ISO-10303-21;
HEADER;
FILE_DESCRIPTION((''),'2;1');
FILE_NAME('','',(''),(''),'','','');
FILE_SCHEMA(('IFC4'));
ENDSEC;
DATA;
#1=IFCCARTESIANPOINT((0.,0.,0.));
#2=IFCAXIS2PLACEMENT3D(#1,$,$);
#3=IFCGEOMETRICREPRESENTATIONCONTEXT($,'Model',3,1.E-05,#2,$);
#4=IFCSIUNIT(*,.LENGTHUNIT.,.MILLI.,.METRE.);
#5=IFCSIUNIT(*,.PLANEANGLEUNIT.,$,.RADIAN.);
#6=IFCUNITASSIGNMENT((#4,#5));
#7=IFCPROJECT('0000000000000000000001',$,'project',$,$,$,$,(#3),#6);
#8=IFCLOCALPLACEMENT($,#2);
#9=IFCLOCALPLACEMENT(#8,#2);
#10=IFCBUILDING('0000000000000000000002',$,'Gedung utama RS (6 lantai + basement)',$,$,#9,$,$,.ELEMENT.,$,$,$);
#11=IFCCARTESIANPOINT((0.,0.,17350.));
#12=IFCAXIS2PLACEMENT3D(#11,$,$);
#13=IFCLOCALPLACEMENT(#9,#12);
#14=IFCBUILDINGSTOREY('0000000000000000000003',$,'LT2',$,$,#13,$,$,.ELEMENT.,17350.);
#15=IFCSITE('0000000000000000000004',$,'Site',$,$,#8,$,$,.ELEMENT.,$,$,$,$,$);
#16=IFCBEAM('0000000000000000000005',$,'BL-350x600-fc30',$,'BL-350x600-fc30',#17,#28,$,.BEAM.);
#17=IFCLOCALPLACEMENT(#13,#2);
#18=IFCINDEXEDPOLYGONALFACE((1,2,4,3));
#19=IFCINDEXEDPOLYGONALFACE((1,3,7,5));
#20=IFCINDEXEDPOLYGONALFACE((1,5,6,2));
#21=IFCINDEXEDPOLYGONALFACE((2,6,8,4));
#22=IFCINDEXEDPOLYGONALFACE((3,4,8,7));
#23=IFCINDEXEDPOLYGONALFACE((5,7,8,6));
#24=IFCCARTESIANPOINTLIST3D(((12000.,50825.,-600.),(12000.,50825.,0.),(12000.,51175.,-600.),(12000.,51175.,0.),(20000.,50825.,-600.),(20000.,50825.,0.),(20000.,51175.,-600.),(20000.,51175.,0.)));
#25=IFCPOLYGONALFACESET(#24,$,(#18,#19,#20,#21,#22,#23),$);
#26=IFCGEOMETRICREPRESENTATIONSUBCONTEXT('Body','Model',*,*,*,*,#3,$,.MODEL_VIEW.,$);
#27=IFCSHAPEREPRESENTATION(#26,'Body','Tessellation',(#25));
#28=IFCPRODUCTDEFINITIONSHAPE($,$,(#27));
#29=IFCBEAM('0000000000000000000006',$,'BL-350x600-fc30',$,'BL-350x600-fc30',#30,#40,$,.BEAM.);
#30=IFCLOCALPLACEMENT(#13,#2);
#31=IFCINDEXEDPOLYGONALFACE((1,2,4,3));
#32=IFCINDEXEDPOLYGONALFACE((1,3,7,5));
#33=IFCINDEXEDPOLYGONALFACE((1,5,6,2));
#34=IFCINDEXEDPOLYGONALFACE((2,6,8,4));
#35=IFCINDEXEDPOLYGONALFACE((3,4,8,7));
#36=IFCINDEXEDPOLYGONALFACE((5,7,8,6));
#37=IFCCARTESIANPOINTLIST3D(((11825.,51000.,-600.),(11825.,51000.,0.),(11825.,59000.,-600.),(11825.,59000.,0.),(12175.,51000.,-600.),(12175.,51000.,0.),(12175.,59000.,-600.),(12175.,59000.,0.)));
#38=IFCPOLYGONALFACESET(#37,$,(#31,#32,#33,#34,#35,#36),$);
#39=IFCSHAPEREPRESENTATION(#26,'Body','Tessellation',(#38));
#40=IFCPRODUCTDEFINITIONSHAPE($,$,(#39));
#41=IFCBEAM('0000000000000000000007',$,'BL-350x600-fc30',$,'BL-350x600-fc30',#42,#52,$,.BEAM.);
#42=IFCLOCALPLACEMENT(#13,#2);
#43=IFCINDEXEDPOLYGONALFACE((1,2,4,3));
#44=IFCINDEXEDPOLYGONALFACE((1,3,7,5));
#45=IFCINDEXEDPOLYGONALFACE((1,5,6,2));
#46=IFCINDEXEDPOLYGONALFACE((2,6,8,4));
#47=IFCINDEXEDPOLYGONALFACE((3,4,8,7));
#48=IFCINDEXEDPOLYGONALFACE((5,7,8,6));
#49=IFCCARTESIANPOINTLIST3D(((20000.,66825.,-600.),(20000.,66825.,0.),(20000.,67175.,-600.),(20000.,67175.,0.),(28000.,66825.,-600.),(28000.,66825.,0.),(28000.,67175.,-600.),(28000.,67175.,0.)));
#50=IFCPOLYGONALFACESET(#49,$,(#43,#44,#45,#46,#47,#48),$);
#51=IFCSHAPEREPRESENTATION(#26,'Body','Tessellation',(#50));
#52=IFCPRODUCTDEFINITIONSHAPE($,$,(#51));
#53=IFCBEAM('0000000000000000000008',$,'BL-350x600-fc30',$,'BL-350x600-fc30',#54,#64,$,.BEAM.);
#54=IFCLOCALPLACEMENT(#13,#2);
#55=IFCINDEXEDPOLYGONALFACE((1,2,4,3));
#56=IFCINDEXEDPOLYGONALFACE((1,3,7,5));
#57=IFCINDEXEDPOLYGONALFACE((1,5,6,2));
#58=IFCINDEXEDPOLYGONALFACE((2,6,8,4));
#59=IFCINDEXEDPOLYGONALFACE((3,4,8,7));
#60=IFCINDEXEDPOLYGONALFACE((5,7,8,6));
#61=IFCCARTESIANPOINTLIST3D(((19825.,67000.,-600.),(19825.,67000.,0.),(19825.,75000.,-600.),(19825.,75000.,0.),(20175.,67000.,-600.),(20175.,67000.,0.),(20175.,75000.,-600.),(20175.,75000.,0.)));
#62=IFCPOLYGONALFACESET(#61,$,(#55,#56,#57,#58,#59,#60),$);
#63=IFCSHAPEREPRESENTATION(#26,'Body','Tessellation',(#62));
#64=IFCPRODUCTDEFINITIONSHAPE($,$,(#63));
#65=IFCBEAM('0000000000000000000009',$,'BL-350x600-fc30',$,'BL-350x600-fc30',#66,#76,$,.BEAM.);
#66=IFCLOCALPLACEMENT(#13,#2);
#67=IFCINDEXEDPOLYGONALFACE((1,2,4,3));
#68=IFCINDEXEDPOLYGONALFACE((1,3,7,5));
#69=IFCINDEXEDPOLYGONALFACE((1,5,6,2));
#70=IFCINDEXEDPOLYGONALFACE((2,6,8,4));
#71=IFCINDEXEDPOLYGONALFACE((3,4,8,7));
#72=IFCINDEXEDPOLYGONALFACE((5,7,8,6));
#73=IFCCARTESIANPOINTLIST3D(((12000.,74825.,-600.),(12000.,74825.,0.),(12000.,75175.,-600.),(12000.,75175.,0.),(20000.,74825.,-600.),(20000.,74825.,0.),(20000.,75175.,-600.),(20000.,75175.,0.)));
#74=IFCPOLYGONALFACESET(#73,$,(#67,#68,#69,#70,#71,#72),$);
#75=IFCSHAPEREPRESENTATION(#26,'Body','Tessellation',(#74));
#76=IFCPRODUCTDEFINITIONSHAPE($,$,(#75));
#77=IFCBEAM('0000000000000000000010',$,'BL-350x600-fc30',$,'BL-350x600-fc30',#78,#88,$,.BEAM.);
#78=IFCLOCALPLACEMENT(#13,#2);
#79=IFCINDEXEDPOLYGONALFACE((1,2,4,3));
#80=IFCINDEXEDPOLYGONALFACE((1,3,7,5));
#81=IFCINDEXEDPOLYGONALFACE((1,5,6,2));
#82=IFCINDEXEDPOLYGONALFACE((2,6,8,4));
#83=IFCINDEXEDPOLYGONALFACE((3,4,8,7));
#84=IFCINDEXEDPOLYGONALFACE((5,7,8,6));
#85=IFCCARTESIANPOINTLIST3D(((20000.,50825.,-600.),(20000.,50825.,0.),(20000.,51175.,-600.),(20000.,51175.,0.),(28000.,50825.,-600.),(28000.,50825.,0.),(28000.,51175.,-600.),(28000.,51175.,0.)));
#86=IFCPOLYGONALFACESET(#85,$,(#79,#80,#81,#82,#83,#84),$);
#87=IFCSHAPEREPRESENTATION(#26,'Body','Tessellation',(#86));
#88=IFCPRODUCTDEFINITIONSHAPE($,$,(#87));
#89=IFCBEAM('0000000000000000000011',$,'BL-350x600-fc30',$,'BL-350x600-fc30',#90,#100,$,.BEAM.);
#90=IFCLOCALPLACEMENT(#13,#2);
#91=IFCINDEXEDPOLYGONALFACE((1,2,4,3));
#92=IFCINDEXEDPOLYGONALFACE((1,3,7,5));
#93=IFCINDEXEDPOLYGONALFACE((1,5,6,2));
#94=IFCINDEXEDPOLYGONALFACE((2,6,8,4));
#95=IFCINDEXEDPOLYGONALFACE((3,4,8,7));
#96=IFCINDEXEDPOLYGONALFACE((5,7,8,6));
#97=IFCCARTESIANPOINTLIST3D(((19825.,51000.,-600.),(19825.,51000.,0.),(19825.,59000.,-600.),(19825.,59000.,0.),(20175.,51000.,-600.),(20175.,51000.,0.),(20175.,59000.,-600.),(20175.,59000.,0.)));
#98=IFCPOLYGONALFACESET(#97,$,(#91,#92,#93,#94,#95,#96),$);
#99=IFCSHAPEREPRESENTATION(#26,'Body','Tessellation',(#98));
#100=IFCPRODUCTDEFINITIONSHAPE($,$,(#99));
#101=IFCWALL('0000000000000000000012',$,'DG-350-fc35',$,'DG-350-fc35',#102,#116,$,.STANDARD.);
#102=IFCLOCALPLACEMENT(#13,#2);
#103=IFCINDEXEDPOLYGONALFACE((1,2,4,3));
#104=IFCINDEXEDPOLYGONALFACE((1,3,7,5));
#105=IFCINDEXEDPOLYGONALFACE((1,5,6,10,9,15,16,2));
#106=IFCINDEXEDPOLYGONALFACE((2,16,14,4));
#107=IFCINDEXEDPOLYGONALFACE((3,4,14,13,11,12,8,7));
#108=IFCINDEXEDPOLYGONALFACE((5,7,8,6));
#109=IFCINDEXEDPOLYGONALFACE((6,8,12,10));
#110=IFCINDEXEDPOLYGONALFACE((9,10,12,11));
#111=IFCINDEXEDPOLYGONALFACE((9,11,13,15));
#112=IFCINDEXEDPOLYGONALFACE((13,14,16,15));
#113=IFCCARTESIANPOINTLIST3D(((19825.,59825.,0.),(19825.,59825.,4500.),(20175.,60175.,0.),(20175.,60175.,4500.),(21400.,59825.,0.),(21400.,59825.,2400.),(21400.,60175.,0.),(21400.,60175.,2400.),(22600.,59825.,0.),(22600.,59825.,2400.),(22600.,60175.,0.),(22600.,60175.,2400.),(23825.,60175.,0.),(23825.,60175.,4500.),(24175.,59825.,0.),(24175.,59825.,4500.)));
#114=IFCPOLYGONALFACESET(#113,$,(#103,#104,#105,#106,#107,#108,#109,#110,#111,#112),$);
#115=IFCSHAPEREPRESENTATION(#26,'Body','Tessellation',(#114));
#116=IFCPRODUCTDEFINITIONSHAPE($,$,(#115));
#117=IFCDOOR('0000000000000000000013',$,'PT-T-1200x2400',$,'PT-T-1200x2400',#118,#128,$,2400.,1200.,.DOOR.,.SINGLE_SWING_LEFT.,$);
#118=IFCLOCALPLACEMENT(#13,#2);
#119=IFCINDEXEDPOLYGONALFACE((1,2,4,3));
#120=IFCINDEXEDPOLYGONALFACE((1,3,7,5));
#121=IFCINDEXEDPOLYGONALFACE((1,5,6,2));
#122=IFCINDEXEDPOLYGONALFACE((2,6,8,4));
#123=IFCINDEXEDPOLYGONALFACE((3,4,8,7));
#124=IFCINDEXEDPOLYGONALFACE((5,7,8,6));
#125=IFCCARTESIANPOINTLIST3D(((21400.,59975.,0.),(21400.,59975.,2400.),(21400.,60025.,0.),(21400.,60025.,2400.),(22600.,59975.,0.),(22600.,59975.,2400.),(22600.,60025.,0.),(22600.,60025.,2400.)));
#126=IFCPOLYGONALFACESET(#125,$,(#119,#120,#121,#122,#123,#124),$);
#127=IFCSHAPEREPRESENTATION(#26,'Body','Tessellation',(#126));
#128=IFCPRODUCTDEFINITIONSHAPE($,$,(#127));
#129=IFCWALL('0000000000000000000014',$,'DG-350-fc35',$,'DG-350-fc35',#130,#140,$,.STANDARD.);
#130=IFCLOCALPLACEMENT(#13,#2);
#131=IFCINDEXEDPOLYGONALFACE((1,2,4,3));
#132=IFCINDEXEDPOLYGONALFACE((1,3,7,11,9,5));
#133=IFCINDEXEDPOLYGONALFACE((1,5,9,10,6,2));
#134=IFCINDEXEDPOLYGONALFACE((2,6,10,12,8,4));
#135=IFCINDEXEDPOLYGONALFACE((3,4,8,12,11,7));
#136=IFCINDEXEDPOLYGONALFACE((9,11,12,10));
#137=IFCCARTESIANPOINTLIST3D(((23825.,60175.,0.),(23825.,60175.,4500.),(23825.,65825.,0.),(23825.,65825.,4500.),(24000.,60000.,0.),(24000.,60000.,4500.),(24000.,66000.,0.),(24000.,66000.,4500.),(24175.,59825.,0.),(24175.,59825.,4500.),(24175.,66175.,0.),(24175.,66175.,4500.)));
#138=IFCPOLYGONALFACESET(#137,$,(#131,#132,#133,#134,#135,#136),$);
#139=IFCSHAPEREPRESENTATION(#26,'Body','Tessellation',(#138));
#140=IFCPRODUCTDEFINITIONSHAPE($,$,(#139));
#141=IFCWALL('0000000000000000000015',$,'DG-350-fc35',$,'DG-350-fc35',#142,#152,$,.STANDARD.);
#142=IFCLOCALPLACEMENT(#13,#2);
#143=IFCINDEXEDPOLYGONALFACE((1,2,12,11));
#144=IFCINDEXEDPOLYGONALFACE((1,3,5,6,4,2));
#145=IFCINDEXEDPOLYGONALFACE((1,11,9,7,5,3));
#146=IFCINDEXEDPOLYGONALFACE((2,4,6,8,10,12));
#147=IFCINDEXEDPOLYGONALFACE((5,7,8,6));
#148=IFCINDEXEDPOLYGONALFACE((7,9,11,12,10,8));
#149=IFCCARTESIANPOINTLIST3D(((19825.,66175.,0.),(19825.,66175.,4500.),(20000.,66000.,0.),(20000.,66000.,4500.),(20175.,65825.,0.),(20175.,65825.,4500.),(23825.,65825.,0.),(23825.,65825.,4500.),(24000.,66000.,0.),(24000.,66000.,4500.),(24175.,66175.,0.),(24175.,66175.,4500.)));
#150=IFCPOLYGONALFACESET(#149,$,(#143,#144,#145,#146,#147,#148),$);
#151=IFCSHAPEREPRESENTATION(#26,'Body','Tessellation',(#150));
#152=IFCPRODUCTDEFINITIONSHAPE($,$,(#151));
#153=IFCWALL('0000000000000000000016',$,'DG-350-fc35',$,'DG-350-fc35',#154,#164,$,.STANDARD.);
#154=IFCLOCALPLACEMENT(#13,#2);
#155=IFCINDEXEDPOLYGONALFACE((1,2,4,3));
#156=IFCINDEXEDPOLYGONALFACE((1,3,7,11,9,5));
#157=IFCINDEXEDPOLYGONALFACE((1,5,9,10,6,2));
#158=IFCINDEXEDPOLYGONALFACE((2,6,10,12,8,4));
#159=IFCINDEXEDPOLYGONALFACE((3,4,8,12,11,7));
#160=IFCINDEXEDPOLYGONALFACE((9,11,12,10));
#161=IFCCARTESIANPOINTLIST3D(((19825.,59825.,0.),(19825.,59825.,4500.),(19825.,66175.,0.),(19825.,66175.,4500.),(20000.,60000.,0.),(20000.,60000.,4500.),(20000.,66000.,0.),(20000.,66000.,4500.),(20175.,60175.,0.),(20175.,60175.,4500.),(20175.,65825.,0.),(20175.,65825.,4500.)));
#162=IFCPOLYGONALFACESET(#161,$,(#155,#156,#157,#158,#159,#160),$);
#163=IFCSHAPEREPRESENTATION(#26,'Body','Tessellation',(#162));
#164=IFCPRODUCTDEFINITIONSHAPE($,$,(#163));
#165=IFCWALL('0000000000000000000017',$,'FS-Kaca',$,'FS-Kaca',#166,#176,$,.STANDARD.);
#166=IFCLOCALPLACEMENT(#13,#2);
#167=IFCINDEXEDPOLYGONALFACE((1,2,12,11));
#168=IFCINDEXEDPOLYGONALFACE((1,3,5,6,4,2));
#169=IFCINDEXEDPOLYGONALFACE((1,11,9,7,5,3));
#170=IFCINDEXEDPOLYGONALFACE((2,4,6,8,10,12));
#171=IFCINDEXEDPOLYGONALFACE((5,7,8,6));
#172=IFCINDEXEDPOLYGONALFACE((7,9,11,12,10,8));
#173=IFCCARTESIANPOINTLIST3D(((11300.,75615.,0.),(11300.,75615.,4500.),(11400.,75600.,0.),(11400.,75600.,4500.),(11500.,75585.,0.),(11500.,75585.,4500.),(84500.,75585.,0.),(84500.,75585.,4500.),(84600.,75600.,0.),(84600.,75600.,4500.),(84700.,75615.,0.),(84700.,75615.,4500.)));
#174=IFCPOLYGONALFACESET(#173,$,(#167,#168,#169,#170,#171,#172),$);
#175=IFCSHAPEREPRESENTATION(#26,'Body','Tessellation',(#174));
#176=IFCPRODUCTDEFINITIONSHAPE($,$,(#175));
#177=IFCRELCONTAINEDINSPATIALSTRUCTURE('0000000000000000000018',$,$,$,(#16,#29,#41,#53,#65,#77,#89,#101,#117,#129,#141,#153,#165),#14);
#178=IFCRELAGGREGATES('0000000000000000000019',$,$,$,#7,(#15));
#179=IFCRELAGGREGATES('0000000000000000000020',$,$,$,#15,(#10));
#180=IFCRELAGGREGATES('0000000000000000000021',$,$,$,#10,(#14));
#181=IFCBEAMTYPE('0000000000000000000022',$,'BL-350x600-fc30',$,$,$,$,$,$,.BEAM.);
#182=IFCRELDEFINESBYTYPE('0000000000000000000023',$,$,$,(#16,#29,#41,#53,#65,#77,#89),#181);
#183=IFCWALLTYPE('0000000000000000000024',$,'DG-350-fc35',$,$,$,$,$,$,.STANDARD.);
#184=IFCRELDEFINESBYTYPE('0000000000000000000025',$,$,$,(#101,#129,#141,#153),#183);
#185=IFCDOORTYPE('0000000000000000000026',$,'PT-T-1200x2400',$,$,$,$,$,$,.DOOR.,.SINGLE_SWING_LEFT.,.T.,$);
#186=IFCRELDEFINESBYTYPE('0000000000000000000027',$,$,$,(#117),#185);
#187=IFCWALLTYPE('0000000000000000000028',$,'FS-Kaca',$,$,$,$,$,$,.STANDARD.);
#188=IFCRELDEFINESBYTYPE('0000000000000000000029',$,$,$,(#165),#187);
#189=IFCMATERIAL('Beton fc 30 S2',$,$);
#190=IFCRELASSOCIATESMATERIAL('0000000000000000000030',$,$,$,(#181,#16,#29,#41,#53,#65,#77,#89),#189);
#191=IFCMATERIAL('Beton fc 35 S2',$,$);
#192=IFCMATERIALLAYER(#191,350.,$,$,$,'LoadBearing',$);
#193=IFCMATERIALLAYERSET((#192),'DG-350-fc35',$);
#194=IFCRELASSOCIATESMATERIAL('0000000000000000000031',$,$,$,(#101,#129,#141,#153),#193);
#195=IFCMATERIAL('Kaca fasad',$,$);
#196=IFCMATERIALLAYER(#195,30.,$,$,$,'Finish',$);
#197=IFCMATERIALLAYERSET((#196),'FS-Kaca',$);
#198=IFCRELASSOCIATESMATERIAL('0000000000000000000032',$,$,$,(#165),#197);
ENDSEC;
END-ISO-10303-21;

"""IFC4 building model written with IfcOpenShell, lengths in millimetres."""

from ifc_helpers import new_model, si_unit, frame, frame_2d, origin, origin_2d, place, context, subcontext, project, spatial, polyline, rectangle, outline, extrude, material, layer, layer_set, layer_usage, material_profile, profile_set, profile_usage, type_object, element, fill, save


model = new_model("IFC4")

# Units and contexts
model_context = context("Model", 3, precision=1e-05, world=origin())
body_context = subcontext(model_context, "Body", "Model", "MODEL_VIEW")
ifc_project = project(units=[si_unit("LENGTHUNIT", "METRE", prefix="MILLI"), si_unit("PLANEANGLEUNIT", "RADIAN")], contexts=[model_context])

# Site, building, storey
site_placement = place(None, origin())
site = spatial("IfcSite", under=ifc_project, at=site_placement, Name="Site", CompositionType="ELEMENT")
building_placement = place(site_placement, origin())
building = spatial("IfcBuilding", under=site, at=building_placement, Name="Gedung utama RS (6 lantai + basement)", CompositionType="ELEMENT")
storey_placement = place(building_placement, frame((0.0, 0.0, 17350.0)))
storey = spatial("IfcBuildingStorey", under=building, at=storey_placement, Name="LT2", CompositionType="ELEMENT", Elevation=17350.0)

# Beams
ifc_material_1 = material(Name="Beton fc 30 S2")
ifc_material_profile_1 = material_profile(ifc_material_1, rectangle(XDim=350.0, YDim=600.0, at=origin_2d()), Name="BL-350x600-fc30")
ifc_profile_set_1 = profile_set([ifc_material_profile_1], Name="BL-350x600-fc30")
ifc_profile_usage_1 = profile_usage(ifc_profile_set_1, cardinal=8)
beam_type = type_object("IfcBeamType", Name="BL-350x600-fc30", PredefinedType="BEAM", material=ifc_profile_set_1)
beam_1_placement = place(storey_placement, frame((12000.0, 51000.0, -300.0)))
element("IfcBeam", 1, at=beam_1_placement, inside=storey, type_object=beam_type, material=ifc_profile_usage_1, Name="BL-350x600-fc30", ObjectType="BL-350x600-fc30", PredefinedType="BEAM", context=body_context, shape_type="SweptSolid", body=[
    extrude(rectangle(XDim=350.0, YDim=600.0, at=origin_2d()), frame((0.0, 0.0, 0.0), z_axis=(1.0, 0.0, 0.0), x_axis=(0.0, 1.0, 0.0)), (0.0, 0.0, 1.0), 8000.0),
])
beam_2_placement = place(storey_placement, frame((12000.0, 51000.0, -300.0)))
element("IfcBeam", 2, at=beam_2_placement, inside=storey, type_object=beam_type, material=ifc_profile_usage_1, Name="BL-350x600-fc30", ObjectType="BL-350x600-fc30", PredefinedType="BEAM", context=body_context, shape_type="SweptSolid", body=[
    extrude(rectangle(XDim=350.0, YDim=600.0, at=origin_2d()), frame((0.0, 0.0, 0.0), z_axis=(0.0, 1.0, 0.0), x_axis=(-1.0, 0.0, 0.0)), (0.0, 0.0, 1.0), 8000.0),
])
beam_3_placement = place(storey_placement, frame((20000.0, 67000.0, -300.0)))
element("IfcBeam", 3, at=beam_3_placement, inside=storey, type_object=beam_type, material=ifc_profile_usage_1, Name="BL-350x600-fc30", ObjectType="BL-350x600-fc30", PredefinedType="BEAM", context=body_context, shape_type="SweptSolid", body=[
    extrude(rectangle(XDim=350.0, YDim=600.0, at=origin_2d()), frame((0.0, 0.0, 0.0), z_axis=(1.0, 0.0, 0.0), x_axis=(0.0, 1.0, 0.0)), (0.0, 0.0, 1.0), 8000.0),
])
beam_4_placement = place(storey_placement, frame((20000.0, 67000.0, -300.0)))
element("IfcBeam", 4, at=beam_4_placement, inside=storey, type_object=beam_type, material=ifc_profile_usage_1, Name="BL-350x600-fc30", ObjectType="BL-350x600-fc30", PredefinedType="BEAM", context=body_context, shape_type="SweptSolid", body=[
    extrude(rectangle(XDim=350.0, YDim=600.0, at=origin_2d()), frame((0.0, 0.0, 0.0), z_axis=(0.0, 1.0, 0.0), x_axis=(-1.0, 0.0, 0.0)), (0.0, 0.0, 1.0), 8000.0),
])
for number, where, name in (
    (5, (12000.0, 75000.0, -300.0), "BL-350x600-fc30"),
    (6, (20000.0, 51000.0, -300.0), "BL-350x600-fc30"),
):
    element("IfcBeam", number, at=place(storey_placement, frame(where)), inside=storey, type_object=beam_type, material=ifc_profile_usage_1, Name=name, ObjectType="BL-350x600-fc30", PredefinedType="BEAM", context=body_context, shape_type="SweptSolid", body=[
        extrude(rectangle(XDim=350.0, YDim=600.0, at=origin_2d()), frame((0.0, 0.0, 0.0), z_axis=(1.0, 0.0, 0.0), x_axis=(0.0, 1.0, 0.0)), (0.0, 0.0, 1.0), 8000.0),
    ])
beam_5_placement = place(storey_placement, frame((20000.0, 51000.0, -300.0)))
element("IfcBeam", 7, at=beam_5_placement, inside=storey, type_object=beam_type, material=ifc_profile_usage_1, Name="BL-350x600-fc30", ObjectType="BL-350x600-fc30", PredefinedType="BEAM", context=body_context, shape_type="SweptSolid", body=[
    extrude(rectangle(XDim=350.0, YDim=600.0, at=origin_2d()), frame((0.0, 0.0, 0.0), z_axis=(0.0, 1.0, 0.0), x_axis=(-1.0, 0.0, 0.0)), (0.0, 0.0, 1.0), 8000.0),
])

# Wall, opening, door
ifc_material_2 = material(Name="Beton fc 35 S2")
ifc_layer_1 = layer(ifc_material_2, 350.0, Category="LoadBearing")
ifc_layer_set_1 = layer_set([ifc_layer_1], Name="DG-350-fc35")
ifc_layer_usage_1 = layer_usage(ifc_layer_set_1, "AXIS2", "NEGATIVE", 175.0)
wall_type_1 = type_object("IfcWallType", Name="DG-350-fc35", PredefinedType="STANDARD")
wall_1_placement = place(storey_placement, frame((20000.0, 60000.0, 0.0), z_axis=(0.0, 0.0, 1.0), x_axis=(1.0, 0.0, 0.0)))
wall_1 = element("IfcWall", 8, at=wall_1_placement, inside=storey, type_object=wall_type_1, material=ifc_layer_usage_1, Name="DG-350-fc35", ObjectType="DG-350-fc35", PredefinedType="STANDARD", context=body_context, shape_type="SweptSolid", body=[
    extrude(outline(polyline([(-175.0, -175.0), (0.0, 0.0), (175.0, 175.0), (3825.0, 175.0), (4000.0, 0.0), (4175.0, -175.0), (-175.0, -175.0)])), origin(), (0.0, 0.0, 1.0), 4500.0),
])
opening_placement = place(wall_1_placement, frame((1400.0, 0.0, 0.0), z_axis=(0.0, 0.0, 1.0), x_axis=(1.0, 0.0, 0.0)))
opening = element("IfcOpeningElement", 9, at=opening_placement, cuts=wall_1, PredefinedType="OPENING", context=body_context, shape_type="SweptSolid", body=[
    extrude(rectangle(XDim=1200.0, YDim=370.0, at=frame_2d((600.0, 0.0))), origin(), (0.0, 0.0, 1.0), 2400.0),
])
door_type = type_object("IfcDoorType", Name="PT-T-1200x2400", OperationType="SINGLE_SWING_LEFT", ParameterTakesPrecedence=True, PredefinedType="DOOR")
door_placement = place(opening_placement, origin())
door = element("IfcDoor", 10, at=door_placement, inside=storey, type_object=door_type, Name="PT-T-1200x2400", ObjectType="PT-T-1200x2400", OperationType="SINGLE_SWING_LEFT", OverallHeight=2400.0, OverallWidth=1200.0, PredefinedType="DOOR", context=body_context, shape_type="SweptSolid", body=[
    extrude(rectangle(XDim=1200.0, YDim=50.0, at=frame_2d((600.0, 0.0))), origin(), (0.0, 0.0, 1.0), 2400.0),
])
fill(opening, door)

# Walls
wall_2_placement = place(storey_placement, frame((24000.0, 60000.0, 0.0), z_axis=(0.0, 0.0, 1.0), x_axis=(0.0, 1.0, 0.0)))
element("IfcWall", 11, at=wall_2_placement, inside=storey, type_object=wall_type_1, material=ifc_layer_usage_1, Name="DG-350-fc35", ObjectType="DG-350-fc35", PredefinedType="STANDARD", context=body_context, shape_type="SweptSolid", body=[
    extrude(outline(polyline([(-175.0, -175.0), (0.0, 0.0), (175.0, 175.0), (5825.0, 175.0), (6000.0, 0.0), (6175.0, -175.0), (-175.0, -175.0)])), origin(), (0.0, 0.0, 1.0), 4500.0),
])
wall_3_placement = place(storey_placement, frame((24000.0, 66000.0, 0.0), z_axis=(0.0, 0.0, 1.0), x_axis=(-1.0, 0.0, 0.0)))
element("IfcWall", 12, at=wall_3_placement, inside=storey, type_object=wall_type_1, material=ifc_layer_usage_1, Name="DG-350-fc35", ObjectType="DG-350-fc35", PredefinedType="STANDARD", context=body_context, shape_type="SweptSolid", body=[
    extrude(outline(polyline([(-175.0, -175.0), (0.0, 0.0), (175.0, 175.0), (3825.0, 175.0), (4000.0, 0.0), (4175.0, -175.0), (-175.0, -175.0)])), origin(), (0.0, 0.0, 1.0), 4500.0),
])
wall_4_placement = place(storey_placement, frame((20000.0, 66000.0, 0.0), z_axis=(0.0, 0.0, 1.0), x_axis=(0.0, -1.0, 0.0)))
element("IfcWall", 13, at=wall_4_placement, inside=storey, type_object=wall_type_1, material=ifc_layer_usage_1, Name="DG-350-fc35", ObjectType="DG-350-fc35", PredefinedType="STANDARD", context=body_context, shape_type="SweptSolid", body=[
    extrude(outline(polyline([(-175.0, -175.0), (0.0, 0.0), (175.0, 175.0), (5825.0, 175.0), (6000.0, 0.0), (6175.0, -175.0), (-175.0, -175.0)])), origin(), (0.0, 0.0, 1.0), 4500.0),
])
ifc_material_3 = material(Name="Kaca fasad")
ifc_layer_2 = layer(ifc_material_3, 30.0, Category="Finish")
ifc_layer_set_2 = layer_set([ifc_layer_2], Name="FS-Kaca")
ifc_layer_usage_2 = layer_usage(ifc_layer_set_2, "AXIS2", "NEGATIVE", 15.0)
wall_type_2 = type_object("IfcWallType", Name="FS-Kaca", PredefinedType="STANDARD")
wall_5_placement = place(storey_placement, frame((11400.0, 75600.0, 0.0), z_axis=(0.0, 0.0, 1.0), x_axis=(1.0, 0.0, 0.0)))
element("IfcWall", 14, at=wall_5_placement, inside=storey, type_object=wall_type_2, material=ifc_layer_usage_2, Name="FS-Kaca", ObjectType="FS-Kaca", PredefinedType="STANDARD", context=body_context, shape_type="SweptSolid", body=[
    extrude(outline(polyline([(100.0, -15.0), (0.0, 0.0), (-100.0, 15.0), (73300.0, 15.0), (73200.0, 0.0), (73100.0, -15.0), (100.0, -15.0)])), origin(), (0.0, 0.0, 1.0), 4500.0),
])

save(model, "model.ifc")
